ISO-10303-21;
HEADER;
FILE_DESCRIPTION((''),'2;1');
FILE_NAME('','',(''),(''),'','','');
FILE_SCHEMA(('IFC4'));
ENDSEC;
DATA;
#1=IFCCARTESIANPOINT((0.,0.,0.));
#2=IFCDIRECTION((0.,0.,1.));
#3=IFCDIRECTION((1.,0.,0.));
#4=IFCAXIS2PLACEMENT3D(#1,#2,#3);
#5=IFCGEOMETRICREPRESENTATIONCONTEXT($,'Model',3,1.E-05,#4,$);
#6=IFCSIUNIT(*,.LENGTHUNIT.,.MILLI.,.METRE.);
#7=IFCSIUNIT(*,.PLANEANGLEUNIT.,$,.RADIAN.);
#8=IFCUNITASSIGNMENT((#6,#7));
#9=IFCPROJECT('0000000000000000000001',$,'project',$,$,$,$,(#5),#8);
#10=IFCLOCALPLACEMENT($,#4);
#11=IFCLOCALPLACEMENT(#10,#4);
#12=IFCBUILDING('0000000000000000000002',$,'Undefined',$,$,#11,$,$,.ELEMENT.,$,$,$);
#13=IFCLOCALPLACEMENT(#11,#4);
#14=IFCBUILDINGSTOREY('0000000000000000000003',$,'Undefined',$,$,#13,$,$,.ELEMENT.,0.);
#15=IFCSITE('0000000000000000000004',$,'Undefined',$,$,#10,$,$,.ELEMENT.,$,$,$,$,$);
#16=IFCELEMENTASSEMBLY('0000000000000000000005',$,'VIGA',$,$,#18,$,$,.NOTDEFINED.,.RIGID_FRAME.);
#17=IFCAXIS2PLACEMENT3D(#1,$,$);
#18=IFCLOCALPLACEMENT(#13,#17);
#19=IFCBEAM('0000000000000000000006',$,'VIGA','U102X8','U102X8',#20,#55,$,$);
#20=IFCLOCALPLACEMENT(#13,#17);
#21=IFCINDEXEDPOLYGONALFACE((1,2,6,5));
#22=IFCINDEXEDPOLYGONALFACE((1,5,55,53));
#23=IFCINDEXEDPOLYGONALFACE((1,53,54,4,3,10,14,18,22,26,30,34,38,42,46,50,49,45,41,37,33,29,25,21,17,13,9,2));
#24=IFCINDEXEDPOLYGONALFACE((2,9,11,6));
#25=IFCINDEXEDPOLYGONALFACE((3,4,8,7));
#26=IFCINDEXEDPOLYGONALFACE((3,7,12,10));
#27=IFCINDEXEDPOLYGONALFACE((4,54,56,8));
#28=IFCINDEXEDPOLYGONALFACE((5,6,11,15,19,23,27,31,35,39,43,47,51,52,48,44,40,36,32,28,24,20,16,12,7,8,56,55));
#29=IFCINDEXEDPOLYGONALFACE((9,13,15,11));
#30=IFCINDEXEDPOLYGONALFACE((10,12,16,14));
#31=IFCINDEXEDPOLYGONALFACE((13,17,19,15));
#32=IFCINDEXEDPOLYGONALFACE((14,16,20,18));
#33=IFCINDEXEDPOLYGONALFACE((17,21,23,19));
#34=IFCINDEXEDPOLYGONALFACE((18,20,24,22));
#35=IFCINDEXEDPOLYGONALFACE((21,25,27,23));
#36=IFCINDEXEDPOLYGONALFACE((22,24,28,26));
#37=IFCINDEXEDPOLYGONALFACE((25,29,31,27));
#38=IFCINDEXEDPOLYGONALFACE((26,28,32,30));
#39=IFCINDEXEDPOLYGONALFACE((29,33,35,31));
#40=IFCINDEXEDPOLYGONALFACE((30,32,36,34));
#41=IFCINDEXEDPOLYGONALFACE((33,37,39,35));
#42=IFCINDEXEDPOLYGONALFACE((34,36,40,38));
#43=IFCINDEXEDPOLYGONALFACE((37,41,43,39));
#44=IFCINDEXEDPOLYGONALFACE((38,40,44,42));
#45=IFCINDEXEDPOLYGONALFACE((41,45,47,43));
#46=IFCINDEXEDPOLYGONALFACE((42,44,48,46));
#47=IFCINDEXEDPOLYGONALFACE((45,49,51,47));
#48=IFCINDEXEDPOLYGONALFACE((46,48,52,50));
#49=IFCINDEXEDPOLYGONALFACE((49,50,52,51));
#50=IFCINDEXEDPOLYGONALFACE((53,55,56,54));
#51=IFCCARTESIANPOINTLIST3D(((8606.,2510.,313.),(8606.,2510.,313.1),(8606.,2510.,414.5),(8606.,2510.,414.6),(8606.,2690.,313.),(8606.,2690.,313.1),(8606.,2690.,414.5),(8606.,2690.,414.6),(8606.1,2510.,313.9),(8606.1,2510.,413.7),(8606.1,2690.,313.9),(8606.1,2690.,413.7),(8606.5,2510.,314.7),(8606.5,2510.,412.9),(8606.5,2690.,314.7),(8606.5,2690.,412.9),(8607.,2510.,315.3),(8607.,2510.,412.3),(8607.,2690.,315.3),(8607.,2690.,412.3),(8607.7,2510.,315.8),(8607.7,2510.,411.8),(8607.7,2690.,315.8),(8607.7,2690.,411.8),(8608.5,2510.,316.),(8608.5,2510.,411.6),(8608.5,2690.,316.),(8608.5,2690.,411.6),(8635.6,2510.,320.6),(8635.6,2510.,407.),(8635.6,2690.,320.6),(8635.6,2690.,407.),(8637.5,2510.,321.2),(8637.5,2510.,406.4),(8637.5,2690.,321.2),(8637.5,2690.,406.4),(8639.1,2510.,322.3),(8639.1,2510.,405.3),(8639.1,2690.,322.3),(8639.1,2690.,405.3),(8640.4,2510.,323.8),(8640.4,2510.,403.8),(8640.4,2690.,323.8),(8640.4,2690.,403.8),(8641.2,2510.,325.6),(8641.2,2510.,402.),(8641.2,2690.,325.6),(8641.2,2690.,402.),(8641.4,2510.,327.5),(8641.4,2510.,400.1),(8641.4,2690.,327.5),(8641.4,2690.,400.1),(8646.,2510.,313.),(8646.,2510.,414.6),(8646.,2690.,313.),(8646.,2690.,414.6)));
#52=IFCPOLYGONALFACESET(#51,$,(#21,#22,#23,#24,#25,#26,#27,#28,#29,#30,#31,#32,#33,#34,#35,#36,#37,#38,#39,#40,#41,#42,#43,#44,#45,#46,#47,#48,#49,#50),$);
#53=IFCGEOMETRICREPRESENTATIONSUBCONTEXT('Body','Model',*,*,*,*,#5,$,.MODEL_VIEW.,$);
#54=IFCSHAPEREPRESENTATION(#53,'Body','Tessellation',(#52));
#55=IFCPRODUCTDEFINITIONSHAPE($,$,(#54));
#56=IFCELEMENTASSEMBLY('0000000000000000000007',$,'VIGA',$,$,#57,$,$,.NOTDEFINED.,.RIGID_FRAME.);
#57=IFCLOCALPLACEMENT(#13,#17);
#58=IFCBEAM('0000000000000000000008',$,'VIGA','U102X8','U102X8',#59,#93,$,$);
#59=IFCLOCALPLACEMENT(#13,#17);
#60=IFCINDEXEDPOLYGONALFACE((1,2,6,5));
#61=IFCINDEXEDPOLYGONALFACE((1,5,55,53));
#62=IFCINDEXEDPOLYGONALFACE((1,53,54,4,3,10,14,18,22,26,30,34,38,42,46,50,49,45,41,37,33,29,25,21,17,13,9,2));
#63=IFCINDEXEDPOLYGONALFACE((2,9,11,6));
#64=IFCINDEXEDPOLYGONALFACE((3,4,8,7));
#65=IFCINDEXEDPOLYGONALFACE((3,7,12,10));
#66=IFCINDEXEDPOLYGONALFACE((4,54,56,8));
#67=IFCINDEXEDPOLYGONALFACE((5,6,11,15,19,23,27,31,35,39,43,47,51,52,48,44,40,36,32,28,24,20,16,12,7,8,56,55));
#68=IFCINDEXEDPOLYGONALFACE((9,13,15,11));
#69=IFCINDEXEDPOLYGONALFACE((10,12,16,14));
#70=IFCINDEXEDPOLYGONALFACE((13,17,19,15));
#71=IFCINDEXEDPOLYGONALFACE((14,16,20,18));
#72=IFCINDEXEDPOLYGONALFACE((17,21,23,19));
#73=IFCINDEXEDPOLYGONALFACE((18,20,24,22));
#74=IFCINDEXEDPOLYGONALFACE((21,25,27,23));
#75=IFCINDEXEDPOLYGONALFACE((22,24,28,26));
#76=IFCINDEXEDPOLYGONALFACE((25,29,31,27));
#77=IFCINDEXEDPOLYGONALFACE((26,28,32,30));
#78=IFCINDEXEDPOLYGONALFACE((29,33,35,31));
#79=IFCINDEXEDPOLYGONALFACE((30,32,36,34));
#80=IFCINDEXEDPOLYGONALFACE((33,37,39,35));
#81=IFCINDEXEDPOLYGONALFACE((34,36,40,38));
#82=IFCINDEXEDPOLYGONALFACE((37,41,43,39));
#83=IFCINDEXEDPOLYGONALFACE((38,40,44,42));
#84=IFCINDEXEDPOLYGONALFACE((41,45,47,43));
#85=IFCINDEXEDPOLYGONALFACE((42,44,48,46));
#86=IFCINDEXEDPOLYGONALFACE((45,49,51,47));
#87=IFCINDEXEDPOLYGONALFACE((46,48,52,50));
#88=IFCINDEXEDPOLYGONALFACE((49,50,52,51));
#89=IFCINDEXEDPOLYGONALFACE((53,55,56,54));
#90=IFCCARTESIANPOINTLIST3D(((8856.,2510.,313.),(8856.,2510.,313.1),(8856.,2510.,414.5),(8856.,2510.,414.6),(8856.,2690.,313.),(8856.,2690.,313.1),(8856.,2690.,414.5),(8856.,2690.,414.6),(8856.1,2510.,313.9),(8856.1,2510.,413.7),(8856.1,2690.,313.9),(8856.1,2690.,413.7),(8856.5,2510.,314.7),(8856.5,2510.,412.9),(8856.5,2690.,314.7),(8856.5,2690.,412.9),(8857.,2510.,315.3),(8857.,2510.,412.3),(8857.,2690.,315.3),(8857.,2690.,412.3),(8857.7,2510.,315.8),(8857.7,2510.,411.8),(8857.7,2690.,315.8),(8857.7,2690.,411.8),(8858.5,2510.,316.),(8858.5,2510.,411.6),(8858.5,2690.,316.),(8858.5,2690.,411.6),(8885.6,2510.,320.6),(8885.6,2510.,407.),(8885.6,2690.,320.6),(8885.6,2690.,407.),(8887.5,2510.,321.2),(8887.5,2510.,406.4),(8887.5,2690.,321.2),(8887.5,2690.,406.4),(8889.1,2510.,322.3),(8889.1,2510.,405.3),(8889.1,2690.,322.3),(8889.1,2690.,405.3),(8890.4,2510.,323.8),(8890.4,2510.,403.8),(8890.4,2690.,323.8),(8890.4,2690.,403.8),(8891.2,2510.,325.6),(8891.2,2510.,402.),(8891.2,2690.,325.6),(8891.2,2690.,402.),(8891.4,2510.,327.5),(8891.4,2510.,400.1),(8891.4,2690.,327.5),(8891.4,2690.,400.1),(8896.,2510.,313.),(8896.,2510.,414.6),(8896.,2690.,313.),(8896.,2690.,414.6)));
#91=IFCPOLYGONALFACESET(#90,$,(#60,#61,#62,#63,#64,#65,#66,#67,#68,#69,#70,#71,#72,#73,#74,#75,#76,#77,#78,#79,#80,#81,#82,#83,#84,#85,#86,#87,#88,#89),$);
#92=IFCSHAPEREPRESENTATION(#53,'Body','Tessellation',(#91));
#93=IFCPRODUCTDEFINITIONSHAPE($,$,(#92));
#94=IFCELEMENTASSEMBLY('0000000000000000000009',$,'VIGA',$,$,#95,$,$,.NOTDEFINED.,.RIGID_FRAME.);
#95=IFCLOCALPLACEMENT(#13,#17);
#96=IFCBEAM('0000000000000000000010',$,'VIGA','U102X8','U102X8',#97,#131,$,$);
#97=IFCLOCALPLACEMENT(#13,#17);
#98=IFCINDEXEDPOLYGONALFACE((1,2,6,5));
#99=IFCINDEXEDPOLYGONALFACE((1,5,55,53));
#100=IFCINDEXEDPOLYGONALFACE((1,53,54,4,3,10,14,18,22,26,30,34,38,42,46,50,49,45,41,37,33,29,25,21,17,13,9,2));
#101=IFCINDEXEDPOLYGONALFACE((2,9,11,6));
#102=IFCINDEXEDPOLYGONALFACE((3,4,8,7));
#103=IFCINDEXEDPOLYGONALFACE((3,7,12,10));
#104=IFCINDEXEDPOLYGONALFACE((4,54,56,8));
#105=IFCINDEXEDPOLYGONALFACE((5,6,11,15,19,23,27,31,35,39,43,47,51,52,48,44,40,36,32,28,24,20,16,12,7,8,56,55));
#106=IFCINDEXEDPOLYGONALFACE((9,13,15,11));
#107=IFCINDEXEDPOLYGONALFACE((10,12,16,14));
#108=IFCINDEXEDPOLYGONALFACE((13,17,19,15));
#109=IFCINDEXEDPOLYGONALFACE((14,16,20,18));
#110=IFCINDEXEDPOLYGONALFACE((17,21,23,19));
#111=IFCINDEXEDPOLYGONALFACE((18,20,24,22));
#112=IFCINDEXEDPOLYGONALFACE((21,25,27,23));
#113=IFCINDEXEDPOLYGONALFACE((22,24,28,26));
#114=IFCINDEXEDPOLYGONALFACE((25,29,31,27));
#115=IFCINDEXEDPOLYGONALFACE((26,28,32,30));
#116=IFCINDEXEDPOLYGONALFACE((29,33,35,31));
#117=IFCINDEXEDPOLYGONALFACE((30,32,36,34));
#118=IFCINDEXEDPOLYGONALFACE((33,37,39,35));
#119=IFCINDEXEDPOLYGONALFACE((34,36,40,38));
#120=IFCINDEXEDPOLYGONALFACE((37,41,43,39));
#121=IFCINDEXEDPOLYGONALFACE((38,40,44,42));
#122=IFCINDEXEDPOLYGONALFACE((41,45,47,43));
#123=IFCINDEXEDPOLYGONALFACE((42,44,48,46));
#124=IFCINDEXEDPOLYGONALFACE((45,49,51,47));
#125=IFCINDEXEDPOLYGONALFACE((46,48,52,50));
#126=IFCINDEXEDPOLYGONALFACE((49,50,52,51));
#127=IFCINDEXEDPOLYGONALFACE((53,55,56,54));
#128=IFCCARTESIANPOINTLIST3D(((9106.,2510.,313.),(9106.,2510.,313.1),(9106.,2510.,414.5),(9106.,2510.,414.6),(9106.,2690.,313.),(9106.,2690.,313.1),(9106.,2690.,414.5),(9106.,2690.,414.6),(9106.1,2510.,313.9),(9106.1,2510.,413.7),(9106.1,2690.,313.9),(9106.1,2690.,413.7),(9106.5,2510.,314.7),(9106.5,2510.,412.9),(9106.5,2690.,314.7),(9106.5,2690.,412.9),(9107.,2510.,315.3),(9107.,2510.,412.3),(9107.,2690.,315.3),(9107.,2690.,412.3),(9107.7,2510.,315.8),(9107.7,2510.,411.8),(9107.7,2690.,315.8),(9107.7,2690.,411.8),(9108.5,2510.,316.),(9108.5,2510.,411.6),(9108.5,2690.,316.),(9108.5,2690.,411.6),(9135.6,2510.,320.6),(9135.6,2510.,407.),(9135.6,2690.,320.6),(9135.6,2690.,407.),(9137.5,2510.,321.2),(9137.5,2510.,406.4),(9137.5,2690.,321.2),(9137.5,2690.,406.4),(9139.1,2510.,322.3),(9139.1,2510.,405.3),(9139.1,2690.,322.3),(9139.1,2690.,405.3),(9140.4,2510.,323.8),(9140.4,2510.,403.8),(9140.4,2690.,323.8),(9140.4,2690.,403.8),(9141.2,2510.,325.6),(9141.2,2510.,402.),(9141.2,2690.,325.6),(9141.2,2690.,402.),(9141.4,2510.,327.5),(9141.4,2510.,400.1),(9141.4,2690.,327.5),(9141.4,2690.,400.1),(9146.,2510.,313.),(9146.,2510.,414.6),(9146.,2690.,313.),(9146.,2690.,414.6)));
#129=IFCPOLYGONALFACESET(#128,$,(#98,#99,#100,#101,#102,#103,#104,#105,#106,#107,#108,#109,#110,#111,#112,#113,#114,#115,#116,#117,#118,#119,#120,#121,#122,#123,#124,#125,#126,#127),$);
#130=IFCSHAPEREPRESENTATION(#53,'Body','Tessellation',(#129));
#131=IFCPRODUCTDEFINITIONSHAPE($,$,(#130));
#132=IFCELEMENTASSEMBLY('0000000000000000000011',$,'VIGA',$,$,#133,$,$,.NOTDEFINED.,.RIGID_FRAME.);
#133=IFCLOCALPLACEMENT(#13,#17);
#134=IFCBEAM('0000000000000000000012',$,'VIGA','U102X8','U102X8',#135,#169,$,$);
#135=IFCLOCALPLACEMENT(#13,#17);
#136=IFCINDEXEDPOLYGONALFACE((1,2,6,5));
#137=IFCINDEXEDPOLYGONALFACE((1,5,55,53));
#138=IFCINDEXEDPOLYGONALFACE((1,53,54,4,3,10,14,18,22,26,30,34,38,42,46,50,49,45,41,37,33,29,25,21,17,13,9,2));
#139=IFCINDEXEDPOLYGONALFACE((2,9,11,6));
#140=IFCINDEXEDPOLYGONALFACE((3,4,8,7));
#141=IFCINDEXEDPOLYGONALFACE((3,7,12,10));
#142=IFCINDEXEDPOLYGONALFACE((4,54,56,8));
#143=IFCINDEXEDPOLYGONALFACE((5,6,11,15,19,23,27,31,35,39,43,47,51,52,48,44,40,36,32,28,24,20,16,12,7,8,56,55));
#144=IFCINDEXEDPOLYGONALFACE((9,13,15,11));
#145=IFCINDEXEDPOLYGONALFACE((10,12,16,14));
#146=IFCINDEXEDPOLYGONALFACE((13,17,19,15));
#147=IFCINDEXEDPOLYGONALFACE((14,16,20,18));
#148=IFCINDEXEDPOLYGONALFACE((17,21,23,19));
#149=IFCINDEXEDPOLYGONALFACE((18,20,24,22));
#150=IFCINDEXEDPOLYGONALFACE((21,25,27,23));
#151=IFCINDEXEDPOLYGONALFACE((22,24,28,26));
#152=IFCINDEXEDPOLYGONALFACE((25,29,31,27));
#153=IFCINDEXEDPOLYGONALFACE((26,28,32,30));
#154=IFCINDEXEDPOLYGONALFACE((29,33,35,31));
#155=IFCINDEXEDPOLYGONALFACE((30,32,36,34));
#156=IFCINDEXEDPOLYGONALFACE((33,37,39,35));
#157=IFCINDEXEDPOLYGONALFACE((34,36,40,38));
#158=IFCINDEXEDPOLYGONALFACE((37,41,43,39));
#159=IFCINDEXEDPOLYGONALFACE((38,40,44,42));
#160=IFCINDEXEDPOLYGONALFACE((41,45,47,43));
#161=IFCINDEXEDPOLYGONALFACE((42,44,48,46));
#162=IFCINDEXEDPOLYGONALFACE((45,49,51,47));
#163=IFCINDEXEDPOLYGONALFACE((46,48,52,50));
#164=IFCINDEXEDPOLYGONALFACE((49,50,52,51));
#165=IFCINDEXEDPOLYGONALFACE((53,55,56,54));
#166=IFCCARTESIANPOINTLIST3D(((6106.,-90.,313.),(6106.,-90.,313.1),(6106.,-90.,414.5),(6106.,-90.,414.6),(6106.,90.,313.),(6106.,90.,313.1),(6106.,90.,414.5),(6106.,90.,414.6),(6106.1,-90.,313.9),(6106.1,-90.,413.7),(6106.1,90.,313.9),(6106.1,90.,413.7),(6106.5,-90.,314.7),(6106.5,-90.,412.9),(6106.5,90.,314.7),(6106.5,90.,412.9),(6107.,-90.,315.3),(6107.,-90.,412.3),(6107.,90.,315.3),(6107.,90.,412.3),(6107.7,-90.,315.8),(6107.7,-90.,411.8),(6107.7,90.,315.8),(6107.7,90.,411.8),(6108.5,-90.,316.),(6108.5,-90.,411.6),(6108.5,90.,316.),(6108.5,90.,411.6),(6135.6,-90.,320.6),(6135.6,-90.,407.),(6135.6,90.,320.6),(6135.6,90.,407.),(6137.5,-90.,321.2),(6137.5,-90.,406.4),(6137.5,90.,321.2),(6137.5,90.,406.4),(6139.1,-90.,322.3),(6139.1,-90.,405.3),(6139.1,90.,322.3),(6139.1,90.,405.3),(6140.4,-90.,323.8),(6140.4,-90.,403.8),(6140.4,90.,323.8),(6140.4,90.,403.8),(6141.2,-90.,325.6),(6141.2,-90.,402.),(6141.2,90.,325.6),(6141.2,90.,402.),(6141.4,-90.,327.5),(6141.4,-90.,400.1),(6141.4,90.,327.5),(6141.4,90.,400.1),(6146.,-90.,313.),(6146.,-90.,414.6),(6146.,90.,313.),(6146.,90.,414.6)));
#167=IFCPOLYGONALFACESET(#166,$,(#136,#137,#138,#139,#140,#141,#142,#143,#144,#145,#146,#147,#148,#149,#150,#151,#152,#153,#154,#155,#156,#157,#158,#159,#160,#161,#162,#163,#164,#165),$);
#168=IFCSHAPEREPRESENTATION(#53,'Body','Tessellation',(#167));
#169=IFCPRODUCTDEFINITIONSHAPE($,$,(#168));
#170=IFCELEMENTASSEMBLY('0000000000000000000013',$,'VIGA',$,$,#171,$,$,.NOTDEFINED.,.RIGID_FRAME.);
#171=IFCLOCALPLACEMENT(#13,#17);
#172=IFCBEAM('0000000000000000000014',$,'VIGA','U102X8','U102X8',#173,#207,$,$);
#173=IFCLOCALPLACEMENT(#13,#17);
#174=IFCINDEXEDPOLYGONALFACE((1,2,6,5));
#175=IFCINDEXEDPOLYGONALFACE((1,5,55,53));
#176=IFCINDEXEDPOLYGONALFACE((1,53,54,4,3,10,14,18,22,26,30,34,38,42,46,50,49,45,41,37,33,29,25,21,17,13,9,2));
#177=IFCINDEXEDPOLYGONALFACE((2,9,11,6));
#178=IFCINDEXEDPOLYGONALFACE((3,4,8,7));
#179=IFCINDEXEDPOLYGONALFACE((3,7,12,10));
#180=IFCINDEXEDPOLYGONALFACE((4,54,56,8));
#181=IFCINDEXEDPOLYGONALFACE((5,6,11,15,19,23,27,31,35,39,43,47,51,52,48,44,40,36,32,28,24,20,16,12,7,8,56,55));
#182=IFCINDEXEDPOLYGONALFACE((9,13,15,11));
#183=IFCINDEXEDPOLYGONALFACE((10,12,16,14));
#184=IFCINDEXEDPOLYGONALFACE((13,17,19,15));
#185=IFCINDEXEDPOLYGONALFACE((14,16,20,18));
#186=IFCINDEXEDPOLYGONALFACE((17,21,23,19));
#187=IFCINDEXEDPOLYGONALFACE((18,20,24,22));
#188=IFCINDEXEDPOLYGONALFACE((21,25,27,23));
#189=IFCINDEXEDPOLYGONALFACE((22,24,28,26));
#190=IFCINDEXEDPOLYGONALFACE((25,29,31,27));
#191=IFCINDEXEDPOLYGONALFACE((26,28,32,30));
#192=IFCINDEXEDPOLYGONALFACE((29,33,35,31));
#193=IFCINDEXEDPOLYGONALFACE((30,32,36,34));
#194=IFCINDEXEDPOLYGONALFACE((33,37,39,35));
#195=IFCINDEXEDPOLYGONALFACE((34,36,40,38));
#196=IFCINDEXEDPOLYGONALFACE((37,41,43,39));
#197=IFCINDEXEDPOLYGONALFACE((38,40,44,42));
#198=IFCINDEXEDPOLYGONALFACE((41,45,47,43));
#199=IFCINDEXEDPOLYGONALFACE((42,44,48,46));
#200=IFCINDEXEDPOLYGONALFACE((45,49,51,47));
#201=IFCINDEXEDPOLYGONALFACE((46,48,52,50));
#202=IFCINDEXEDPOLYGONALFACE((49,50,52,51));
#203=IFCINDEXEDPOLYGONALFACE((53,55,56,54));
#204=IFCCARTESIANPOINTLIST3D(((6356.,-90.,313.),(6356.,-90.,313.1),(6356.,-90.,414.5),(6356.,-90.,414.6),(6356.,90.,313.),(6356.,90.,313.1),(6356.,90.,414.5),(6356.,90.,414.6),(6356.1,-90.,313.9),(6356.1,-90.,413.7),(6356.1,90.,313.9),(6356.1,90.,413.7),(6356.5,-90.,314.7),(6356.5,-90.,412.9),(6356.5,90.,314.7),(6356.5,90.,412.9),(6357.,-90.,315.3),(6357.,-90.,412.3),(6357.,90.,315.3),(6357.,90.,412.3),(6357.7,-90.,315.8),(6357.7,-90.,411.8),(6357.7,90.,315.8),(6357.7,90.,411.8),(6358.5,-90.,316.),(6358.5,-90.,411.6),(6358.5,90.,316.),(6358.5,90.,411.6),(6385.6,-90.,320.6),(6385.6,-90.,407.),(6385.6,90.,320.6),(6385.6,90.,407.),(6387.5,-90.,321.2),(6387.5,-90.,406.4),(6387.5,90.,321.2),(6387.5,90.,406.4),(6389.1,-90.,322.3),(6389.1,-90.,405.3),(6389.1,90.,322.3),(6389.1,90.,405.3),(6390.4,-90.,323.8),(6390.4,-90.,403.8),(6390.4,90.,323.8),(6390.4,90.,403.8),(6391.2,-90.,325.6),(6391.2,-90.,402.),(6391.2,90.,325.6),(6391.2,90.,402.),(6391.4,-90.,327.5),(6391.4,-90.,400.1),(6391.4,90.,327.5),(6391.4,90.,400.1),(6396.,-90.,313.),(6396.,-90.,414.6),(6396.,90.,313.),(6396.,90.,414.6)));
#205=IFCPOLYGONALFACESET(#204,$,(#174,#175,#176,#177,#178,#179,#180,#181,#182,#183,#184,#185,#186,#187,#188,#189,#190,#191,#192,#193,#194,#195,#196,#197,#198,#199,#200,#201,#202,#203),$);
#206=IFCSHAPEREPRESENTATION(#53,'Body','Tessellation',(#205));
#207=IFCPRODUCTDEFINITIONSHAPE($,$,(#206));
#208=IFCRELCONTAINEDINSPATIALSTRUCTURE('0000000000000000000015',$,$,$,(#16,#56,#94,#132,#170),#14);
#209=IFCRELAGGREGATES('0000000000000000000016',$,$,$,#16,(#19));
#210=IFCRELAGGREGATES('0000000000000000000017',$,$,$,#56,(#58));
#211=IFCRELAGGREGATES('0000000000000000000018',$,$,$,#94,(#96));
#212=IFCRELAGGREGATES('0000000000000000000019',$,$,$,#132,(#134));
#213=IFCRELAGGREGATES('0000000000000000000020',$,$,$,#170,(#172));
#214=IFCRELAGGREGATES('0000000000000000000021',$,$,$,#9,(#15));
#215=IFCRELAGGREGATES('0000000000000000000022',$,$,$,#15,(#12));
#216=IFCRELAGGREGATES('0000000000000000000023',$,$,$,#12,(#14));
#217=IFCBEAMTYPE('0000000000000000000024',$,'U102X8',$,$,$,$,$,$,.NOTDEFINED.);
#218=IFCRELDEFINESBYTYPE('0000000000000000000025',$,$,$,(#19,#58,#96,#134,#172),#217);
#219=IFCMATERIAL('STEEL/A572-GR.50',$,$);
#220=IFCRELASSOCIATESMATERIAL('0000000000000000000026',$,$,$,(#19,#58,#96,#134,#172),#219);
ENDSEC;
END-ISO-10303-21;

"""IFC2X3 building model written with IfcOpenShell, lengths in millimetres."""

from ifc_helpers import new_model, si_unit, frame, origin_with_axes, origin_2d_with_axis, place, context, subcontext, project, spatial, u_section, extrude, material, type_object, element, aggregate, save


model = new_model("IFC2X3")

# Units and contexts
model_context = context("Model", 3, precision=1e-05, world=origin_with_axes())
body_context = subcontext(model_context, "Body", "Model", "MODEL_VIEW")
ifc_project = project(units=[si_unit("LENGTHUNIT", "METRE", prefix="MILLI"), si_unit("PLANEANGLEUNIT", "RADIAN")], contexts=[model_context])

# Site, building, storey
site_placement = place(None, origin_with_axes())
site = spatial("IfcSite", under=ifc_project, at=site_placement, Name="Undefined", CompositionType="ELEMENT")
building_placement = place(site_placement, origin_with_axes())
building = spatial("IfcBuilding", under=site, at=building_placement, Name="Undefined", CompositionType="ELEMENT")
storey_placement = place(building_placement, origin_with_axes())
storey = spatial("IfcBuildingStorey", under=building, at=storey_placement, Name="Undefined", CompositionType="ELEMENT", Elevation=0.0)

# Element assemblies, beams
ifc_material_1 = material(Name="STEEL/A572-GR.50")
beam_type = type_object("IfcBeamType", Name="U102X8", PredefinedType="NOTDEFINED")
assembly_1_placement = place(storey_placement, origin_with_axes())
assembly_1 = element("IfcElementAssembly", 1, at=assembly_1_placement, inside=storey, Name="VIGA", AssemblyPlace="NOTDEFINED", PredefinedType="RIGID_FRAME")
beam_1_placement = place(assembly_1_placement, frame((8626.0, 2690.0, 363.8), z_axis=(0.0, 0.0, 1.0), x_axis=(0.0, -1.0, 0.0)))
beam_1 = element("IfcBeam", 2, at=beam_1_placement, type_object=beam_type, material=ifc_material_1, Name="VIGA", Description="U102X8", ObjectType="U102X8", context=body_context, shape_type="SweptSolid", body=[
    extrude(u_section(Depth=101.6, FlangeWidth=40.0, WebThickness=4.6, FlangeThickness=6.0, FilletRadius=7.0, EdgeRadius=3.0, FlangeSlope=0.16839, at=origin_2d_with_axis()), frame((180.0, 0.0, 0.0), z_axis=(-1.0, 0.0, 0.0), x_axis=(0.0, -1.0, 0.0)), (0.0, 0.0, 1.0), 180.0),
])
aggregate(assembly_1, [beam_1])
assembly_2_placement = place(storey_placement, origin_with_axes())
assembly_2 = element("IfcElementAssembly", 3, at=assembly_2_placement, inside=storey, Name="VIGA", AssemblyPlace="NOTDEFINED", PredefinedType="RIGID_FRAME")
beam_2_placement = place(assembly_2_placement, frame((8876.0, 2690.0, 363.8), z_axis=(0.0, 0.0, 1.0), x_axis=(0.0, -1.0, 0.0)))
beam_2 = element("IfcBeam", 4, at=beam_2_placement, type_object=beam_type, material=ifc_material_1, Name="VIGA", Description="U102X8", ObjectType="U102X8", context=body_context, shape_type="SweptSolid", body=[
    extrude(u_section(Depth=101.6, FlangeWidth=40.0, WebThickness=4.6, FlangeThickness=6.0, FilletRadius=7.0, EdgeRadius=3.0, FlangeSlope=0.16839, at=origin_2d_with_axis()), frame((180.0, 0.0, 0.0), z_axis=(-1.0, 0.0, 0.0), x_axis=(0.0, -1.0, 0.0)), (0.0, 0.0, 1.0), 180.0),
])
aggregate(assembly_2, [beam_2])
assembly_3_placement = place(storey_placement, origin_with_axes())
assembly_3 = element("IfcElementAssembly", 5, at=assembly_3_placement, inside=storey, Name="VIGA", AssemblyPlace="NOTDEFINED", PredefinedType="RIGID_FRAME")
beam_3_placement = place(assembly_3_placement, frame((9126.0, 2690.0, 363.8), z_axis=(0.0, 0.0, 1.0), x_axis=(0.0, -1.0, 0.0)))
beam_3 = element("IfcBeam", 6, at=beam_3_placement, type_object=beam_type, material=ifc_material_1, Name="VIGA", Description="U102X8", ObjectType="U102X8", context=body_context, shape_type="SweptSolid", body=[
    extrude(u_section(Depth=101.6, FlangeWidth=40.0, WebThickness=4.6, FlangeThickness=6.0, FilletRadius=7.0, EdgeRadius=3.0, FlangeSlope=0.16839, at=origin_2d_with_axis()), frame((180.0, 0.0, 0.0), z_axis=(-1.0, 0.0, 0.0), x_axis=(0.0, -1.0, 0.0)), (0.0, 0.0, 1.0), 180.0),
])
aggregate(assembly_3, [beam_3])
assembly_4_placement = place(storey_placement, origin_with_axes())
assembly_4 = element("IfcElementAssembly", 7, at=assembly_4_placement, inside=storey, Name="VIGA", AssemblyPlace="NOTDEFINED", PredefinedType="RIGID_FRAME")
beam_4_placement = place(assembly_4_placement, frame((6126.0, 90.0, 363.8), z_axis=(0.0, 0.0, 1.0), x_axis=(0.0, -1.0, 0.0)))
beam_4 = element("IfcBeam", 8, at=beam_4_placement, type_object=beam_type, material=ifc_material_1, Name="VIGA", Description="U102X8", ObjectType="U102X8", context=body_context, shape_type="SweptSolid", body=[
    extrude(u_section(Depth=101.6, FlangeWidth=40.0, WebThickness=4.6, FlangeThickness=6.0, FilletRadius=7.0, EdgeRadius=3.0, FlangeSlope=0.16839, at=origin_2d_with_axis()), frame((180.0, 0.0, 0.0), z_axis=(-1.0, 0.0, 0.0), x_axis=(0.0, -1.0, 0.0)), (0.0, 0.0, 1.0), 180.0),
])
aggregate(assembly_4, [beam_4])
assembly_5_placement = place(storey_placement, origin_with_axes())
assembly_5 = element("IfcElementAssembly", 9, at=assembly_5_placement, inside=storey, Name="VIGA", AssemblyPlace="NOTDEFINED", PredefinedType="RIGID_FRAME")
beam_5_placement = place(assembly_5_placement, frame((6376.0, 90.0, 363.8), z_axis=(0.0, 0.0, 1.0), x_axis=(0.0, -1.0, 0.0)))
beam_5 = element("IfcBeam", 10, at=beam_5_placement, type_object=beam_type, material=ifc_material_1, Name="VIGA", Description="U102X8", ObjectType="U102X8", context=body_context, shape_type="SweptSolid", body=[
    extrude(u_section(Depth=101.6, FlangeWidth=40.0, WebThickness=4.6, FlangeThickness=6.0, FilletRadius=7.0, EdgeRadius=3.0, FlangeSlope=0.16839, at=origin_2d_with_axis()), frame((180.0, 0.0, 0.0), z_axis=(-1.0, 0.0, 0.0), x_axis=(0.0, -1.0, 0.0)), (0.0, 0.0, 1.0), 180.0),
])
aggregate(assembly_5, [beam_5])

save(model, "model.ifc")
